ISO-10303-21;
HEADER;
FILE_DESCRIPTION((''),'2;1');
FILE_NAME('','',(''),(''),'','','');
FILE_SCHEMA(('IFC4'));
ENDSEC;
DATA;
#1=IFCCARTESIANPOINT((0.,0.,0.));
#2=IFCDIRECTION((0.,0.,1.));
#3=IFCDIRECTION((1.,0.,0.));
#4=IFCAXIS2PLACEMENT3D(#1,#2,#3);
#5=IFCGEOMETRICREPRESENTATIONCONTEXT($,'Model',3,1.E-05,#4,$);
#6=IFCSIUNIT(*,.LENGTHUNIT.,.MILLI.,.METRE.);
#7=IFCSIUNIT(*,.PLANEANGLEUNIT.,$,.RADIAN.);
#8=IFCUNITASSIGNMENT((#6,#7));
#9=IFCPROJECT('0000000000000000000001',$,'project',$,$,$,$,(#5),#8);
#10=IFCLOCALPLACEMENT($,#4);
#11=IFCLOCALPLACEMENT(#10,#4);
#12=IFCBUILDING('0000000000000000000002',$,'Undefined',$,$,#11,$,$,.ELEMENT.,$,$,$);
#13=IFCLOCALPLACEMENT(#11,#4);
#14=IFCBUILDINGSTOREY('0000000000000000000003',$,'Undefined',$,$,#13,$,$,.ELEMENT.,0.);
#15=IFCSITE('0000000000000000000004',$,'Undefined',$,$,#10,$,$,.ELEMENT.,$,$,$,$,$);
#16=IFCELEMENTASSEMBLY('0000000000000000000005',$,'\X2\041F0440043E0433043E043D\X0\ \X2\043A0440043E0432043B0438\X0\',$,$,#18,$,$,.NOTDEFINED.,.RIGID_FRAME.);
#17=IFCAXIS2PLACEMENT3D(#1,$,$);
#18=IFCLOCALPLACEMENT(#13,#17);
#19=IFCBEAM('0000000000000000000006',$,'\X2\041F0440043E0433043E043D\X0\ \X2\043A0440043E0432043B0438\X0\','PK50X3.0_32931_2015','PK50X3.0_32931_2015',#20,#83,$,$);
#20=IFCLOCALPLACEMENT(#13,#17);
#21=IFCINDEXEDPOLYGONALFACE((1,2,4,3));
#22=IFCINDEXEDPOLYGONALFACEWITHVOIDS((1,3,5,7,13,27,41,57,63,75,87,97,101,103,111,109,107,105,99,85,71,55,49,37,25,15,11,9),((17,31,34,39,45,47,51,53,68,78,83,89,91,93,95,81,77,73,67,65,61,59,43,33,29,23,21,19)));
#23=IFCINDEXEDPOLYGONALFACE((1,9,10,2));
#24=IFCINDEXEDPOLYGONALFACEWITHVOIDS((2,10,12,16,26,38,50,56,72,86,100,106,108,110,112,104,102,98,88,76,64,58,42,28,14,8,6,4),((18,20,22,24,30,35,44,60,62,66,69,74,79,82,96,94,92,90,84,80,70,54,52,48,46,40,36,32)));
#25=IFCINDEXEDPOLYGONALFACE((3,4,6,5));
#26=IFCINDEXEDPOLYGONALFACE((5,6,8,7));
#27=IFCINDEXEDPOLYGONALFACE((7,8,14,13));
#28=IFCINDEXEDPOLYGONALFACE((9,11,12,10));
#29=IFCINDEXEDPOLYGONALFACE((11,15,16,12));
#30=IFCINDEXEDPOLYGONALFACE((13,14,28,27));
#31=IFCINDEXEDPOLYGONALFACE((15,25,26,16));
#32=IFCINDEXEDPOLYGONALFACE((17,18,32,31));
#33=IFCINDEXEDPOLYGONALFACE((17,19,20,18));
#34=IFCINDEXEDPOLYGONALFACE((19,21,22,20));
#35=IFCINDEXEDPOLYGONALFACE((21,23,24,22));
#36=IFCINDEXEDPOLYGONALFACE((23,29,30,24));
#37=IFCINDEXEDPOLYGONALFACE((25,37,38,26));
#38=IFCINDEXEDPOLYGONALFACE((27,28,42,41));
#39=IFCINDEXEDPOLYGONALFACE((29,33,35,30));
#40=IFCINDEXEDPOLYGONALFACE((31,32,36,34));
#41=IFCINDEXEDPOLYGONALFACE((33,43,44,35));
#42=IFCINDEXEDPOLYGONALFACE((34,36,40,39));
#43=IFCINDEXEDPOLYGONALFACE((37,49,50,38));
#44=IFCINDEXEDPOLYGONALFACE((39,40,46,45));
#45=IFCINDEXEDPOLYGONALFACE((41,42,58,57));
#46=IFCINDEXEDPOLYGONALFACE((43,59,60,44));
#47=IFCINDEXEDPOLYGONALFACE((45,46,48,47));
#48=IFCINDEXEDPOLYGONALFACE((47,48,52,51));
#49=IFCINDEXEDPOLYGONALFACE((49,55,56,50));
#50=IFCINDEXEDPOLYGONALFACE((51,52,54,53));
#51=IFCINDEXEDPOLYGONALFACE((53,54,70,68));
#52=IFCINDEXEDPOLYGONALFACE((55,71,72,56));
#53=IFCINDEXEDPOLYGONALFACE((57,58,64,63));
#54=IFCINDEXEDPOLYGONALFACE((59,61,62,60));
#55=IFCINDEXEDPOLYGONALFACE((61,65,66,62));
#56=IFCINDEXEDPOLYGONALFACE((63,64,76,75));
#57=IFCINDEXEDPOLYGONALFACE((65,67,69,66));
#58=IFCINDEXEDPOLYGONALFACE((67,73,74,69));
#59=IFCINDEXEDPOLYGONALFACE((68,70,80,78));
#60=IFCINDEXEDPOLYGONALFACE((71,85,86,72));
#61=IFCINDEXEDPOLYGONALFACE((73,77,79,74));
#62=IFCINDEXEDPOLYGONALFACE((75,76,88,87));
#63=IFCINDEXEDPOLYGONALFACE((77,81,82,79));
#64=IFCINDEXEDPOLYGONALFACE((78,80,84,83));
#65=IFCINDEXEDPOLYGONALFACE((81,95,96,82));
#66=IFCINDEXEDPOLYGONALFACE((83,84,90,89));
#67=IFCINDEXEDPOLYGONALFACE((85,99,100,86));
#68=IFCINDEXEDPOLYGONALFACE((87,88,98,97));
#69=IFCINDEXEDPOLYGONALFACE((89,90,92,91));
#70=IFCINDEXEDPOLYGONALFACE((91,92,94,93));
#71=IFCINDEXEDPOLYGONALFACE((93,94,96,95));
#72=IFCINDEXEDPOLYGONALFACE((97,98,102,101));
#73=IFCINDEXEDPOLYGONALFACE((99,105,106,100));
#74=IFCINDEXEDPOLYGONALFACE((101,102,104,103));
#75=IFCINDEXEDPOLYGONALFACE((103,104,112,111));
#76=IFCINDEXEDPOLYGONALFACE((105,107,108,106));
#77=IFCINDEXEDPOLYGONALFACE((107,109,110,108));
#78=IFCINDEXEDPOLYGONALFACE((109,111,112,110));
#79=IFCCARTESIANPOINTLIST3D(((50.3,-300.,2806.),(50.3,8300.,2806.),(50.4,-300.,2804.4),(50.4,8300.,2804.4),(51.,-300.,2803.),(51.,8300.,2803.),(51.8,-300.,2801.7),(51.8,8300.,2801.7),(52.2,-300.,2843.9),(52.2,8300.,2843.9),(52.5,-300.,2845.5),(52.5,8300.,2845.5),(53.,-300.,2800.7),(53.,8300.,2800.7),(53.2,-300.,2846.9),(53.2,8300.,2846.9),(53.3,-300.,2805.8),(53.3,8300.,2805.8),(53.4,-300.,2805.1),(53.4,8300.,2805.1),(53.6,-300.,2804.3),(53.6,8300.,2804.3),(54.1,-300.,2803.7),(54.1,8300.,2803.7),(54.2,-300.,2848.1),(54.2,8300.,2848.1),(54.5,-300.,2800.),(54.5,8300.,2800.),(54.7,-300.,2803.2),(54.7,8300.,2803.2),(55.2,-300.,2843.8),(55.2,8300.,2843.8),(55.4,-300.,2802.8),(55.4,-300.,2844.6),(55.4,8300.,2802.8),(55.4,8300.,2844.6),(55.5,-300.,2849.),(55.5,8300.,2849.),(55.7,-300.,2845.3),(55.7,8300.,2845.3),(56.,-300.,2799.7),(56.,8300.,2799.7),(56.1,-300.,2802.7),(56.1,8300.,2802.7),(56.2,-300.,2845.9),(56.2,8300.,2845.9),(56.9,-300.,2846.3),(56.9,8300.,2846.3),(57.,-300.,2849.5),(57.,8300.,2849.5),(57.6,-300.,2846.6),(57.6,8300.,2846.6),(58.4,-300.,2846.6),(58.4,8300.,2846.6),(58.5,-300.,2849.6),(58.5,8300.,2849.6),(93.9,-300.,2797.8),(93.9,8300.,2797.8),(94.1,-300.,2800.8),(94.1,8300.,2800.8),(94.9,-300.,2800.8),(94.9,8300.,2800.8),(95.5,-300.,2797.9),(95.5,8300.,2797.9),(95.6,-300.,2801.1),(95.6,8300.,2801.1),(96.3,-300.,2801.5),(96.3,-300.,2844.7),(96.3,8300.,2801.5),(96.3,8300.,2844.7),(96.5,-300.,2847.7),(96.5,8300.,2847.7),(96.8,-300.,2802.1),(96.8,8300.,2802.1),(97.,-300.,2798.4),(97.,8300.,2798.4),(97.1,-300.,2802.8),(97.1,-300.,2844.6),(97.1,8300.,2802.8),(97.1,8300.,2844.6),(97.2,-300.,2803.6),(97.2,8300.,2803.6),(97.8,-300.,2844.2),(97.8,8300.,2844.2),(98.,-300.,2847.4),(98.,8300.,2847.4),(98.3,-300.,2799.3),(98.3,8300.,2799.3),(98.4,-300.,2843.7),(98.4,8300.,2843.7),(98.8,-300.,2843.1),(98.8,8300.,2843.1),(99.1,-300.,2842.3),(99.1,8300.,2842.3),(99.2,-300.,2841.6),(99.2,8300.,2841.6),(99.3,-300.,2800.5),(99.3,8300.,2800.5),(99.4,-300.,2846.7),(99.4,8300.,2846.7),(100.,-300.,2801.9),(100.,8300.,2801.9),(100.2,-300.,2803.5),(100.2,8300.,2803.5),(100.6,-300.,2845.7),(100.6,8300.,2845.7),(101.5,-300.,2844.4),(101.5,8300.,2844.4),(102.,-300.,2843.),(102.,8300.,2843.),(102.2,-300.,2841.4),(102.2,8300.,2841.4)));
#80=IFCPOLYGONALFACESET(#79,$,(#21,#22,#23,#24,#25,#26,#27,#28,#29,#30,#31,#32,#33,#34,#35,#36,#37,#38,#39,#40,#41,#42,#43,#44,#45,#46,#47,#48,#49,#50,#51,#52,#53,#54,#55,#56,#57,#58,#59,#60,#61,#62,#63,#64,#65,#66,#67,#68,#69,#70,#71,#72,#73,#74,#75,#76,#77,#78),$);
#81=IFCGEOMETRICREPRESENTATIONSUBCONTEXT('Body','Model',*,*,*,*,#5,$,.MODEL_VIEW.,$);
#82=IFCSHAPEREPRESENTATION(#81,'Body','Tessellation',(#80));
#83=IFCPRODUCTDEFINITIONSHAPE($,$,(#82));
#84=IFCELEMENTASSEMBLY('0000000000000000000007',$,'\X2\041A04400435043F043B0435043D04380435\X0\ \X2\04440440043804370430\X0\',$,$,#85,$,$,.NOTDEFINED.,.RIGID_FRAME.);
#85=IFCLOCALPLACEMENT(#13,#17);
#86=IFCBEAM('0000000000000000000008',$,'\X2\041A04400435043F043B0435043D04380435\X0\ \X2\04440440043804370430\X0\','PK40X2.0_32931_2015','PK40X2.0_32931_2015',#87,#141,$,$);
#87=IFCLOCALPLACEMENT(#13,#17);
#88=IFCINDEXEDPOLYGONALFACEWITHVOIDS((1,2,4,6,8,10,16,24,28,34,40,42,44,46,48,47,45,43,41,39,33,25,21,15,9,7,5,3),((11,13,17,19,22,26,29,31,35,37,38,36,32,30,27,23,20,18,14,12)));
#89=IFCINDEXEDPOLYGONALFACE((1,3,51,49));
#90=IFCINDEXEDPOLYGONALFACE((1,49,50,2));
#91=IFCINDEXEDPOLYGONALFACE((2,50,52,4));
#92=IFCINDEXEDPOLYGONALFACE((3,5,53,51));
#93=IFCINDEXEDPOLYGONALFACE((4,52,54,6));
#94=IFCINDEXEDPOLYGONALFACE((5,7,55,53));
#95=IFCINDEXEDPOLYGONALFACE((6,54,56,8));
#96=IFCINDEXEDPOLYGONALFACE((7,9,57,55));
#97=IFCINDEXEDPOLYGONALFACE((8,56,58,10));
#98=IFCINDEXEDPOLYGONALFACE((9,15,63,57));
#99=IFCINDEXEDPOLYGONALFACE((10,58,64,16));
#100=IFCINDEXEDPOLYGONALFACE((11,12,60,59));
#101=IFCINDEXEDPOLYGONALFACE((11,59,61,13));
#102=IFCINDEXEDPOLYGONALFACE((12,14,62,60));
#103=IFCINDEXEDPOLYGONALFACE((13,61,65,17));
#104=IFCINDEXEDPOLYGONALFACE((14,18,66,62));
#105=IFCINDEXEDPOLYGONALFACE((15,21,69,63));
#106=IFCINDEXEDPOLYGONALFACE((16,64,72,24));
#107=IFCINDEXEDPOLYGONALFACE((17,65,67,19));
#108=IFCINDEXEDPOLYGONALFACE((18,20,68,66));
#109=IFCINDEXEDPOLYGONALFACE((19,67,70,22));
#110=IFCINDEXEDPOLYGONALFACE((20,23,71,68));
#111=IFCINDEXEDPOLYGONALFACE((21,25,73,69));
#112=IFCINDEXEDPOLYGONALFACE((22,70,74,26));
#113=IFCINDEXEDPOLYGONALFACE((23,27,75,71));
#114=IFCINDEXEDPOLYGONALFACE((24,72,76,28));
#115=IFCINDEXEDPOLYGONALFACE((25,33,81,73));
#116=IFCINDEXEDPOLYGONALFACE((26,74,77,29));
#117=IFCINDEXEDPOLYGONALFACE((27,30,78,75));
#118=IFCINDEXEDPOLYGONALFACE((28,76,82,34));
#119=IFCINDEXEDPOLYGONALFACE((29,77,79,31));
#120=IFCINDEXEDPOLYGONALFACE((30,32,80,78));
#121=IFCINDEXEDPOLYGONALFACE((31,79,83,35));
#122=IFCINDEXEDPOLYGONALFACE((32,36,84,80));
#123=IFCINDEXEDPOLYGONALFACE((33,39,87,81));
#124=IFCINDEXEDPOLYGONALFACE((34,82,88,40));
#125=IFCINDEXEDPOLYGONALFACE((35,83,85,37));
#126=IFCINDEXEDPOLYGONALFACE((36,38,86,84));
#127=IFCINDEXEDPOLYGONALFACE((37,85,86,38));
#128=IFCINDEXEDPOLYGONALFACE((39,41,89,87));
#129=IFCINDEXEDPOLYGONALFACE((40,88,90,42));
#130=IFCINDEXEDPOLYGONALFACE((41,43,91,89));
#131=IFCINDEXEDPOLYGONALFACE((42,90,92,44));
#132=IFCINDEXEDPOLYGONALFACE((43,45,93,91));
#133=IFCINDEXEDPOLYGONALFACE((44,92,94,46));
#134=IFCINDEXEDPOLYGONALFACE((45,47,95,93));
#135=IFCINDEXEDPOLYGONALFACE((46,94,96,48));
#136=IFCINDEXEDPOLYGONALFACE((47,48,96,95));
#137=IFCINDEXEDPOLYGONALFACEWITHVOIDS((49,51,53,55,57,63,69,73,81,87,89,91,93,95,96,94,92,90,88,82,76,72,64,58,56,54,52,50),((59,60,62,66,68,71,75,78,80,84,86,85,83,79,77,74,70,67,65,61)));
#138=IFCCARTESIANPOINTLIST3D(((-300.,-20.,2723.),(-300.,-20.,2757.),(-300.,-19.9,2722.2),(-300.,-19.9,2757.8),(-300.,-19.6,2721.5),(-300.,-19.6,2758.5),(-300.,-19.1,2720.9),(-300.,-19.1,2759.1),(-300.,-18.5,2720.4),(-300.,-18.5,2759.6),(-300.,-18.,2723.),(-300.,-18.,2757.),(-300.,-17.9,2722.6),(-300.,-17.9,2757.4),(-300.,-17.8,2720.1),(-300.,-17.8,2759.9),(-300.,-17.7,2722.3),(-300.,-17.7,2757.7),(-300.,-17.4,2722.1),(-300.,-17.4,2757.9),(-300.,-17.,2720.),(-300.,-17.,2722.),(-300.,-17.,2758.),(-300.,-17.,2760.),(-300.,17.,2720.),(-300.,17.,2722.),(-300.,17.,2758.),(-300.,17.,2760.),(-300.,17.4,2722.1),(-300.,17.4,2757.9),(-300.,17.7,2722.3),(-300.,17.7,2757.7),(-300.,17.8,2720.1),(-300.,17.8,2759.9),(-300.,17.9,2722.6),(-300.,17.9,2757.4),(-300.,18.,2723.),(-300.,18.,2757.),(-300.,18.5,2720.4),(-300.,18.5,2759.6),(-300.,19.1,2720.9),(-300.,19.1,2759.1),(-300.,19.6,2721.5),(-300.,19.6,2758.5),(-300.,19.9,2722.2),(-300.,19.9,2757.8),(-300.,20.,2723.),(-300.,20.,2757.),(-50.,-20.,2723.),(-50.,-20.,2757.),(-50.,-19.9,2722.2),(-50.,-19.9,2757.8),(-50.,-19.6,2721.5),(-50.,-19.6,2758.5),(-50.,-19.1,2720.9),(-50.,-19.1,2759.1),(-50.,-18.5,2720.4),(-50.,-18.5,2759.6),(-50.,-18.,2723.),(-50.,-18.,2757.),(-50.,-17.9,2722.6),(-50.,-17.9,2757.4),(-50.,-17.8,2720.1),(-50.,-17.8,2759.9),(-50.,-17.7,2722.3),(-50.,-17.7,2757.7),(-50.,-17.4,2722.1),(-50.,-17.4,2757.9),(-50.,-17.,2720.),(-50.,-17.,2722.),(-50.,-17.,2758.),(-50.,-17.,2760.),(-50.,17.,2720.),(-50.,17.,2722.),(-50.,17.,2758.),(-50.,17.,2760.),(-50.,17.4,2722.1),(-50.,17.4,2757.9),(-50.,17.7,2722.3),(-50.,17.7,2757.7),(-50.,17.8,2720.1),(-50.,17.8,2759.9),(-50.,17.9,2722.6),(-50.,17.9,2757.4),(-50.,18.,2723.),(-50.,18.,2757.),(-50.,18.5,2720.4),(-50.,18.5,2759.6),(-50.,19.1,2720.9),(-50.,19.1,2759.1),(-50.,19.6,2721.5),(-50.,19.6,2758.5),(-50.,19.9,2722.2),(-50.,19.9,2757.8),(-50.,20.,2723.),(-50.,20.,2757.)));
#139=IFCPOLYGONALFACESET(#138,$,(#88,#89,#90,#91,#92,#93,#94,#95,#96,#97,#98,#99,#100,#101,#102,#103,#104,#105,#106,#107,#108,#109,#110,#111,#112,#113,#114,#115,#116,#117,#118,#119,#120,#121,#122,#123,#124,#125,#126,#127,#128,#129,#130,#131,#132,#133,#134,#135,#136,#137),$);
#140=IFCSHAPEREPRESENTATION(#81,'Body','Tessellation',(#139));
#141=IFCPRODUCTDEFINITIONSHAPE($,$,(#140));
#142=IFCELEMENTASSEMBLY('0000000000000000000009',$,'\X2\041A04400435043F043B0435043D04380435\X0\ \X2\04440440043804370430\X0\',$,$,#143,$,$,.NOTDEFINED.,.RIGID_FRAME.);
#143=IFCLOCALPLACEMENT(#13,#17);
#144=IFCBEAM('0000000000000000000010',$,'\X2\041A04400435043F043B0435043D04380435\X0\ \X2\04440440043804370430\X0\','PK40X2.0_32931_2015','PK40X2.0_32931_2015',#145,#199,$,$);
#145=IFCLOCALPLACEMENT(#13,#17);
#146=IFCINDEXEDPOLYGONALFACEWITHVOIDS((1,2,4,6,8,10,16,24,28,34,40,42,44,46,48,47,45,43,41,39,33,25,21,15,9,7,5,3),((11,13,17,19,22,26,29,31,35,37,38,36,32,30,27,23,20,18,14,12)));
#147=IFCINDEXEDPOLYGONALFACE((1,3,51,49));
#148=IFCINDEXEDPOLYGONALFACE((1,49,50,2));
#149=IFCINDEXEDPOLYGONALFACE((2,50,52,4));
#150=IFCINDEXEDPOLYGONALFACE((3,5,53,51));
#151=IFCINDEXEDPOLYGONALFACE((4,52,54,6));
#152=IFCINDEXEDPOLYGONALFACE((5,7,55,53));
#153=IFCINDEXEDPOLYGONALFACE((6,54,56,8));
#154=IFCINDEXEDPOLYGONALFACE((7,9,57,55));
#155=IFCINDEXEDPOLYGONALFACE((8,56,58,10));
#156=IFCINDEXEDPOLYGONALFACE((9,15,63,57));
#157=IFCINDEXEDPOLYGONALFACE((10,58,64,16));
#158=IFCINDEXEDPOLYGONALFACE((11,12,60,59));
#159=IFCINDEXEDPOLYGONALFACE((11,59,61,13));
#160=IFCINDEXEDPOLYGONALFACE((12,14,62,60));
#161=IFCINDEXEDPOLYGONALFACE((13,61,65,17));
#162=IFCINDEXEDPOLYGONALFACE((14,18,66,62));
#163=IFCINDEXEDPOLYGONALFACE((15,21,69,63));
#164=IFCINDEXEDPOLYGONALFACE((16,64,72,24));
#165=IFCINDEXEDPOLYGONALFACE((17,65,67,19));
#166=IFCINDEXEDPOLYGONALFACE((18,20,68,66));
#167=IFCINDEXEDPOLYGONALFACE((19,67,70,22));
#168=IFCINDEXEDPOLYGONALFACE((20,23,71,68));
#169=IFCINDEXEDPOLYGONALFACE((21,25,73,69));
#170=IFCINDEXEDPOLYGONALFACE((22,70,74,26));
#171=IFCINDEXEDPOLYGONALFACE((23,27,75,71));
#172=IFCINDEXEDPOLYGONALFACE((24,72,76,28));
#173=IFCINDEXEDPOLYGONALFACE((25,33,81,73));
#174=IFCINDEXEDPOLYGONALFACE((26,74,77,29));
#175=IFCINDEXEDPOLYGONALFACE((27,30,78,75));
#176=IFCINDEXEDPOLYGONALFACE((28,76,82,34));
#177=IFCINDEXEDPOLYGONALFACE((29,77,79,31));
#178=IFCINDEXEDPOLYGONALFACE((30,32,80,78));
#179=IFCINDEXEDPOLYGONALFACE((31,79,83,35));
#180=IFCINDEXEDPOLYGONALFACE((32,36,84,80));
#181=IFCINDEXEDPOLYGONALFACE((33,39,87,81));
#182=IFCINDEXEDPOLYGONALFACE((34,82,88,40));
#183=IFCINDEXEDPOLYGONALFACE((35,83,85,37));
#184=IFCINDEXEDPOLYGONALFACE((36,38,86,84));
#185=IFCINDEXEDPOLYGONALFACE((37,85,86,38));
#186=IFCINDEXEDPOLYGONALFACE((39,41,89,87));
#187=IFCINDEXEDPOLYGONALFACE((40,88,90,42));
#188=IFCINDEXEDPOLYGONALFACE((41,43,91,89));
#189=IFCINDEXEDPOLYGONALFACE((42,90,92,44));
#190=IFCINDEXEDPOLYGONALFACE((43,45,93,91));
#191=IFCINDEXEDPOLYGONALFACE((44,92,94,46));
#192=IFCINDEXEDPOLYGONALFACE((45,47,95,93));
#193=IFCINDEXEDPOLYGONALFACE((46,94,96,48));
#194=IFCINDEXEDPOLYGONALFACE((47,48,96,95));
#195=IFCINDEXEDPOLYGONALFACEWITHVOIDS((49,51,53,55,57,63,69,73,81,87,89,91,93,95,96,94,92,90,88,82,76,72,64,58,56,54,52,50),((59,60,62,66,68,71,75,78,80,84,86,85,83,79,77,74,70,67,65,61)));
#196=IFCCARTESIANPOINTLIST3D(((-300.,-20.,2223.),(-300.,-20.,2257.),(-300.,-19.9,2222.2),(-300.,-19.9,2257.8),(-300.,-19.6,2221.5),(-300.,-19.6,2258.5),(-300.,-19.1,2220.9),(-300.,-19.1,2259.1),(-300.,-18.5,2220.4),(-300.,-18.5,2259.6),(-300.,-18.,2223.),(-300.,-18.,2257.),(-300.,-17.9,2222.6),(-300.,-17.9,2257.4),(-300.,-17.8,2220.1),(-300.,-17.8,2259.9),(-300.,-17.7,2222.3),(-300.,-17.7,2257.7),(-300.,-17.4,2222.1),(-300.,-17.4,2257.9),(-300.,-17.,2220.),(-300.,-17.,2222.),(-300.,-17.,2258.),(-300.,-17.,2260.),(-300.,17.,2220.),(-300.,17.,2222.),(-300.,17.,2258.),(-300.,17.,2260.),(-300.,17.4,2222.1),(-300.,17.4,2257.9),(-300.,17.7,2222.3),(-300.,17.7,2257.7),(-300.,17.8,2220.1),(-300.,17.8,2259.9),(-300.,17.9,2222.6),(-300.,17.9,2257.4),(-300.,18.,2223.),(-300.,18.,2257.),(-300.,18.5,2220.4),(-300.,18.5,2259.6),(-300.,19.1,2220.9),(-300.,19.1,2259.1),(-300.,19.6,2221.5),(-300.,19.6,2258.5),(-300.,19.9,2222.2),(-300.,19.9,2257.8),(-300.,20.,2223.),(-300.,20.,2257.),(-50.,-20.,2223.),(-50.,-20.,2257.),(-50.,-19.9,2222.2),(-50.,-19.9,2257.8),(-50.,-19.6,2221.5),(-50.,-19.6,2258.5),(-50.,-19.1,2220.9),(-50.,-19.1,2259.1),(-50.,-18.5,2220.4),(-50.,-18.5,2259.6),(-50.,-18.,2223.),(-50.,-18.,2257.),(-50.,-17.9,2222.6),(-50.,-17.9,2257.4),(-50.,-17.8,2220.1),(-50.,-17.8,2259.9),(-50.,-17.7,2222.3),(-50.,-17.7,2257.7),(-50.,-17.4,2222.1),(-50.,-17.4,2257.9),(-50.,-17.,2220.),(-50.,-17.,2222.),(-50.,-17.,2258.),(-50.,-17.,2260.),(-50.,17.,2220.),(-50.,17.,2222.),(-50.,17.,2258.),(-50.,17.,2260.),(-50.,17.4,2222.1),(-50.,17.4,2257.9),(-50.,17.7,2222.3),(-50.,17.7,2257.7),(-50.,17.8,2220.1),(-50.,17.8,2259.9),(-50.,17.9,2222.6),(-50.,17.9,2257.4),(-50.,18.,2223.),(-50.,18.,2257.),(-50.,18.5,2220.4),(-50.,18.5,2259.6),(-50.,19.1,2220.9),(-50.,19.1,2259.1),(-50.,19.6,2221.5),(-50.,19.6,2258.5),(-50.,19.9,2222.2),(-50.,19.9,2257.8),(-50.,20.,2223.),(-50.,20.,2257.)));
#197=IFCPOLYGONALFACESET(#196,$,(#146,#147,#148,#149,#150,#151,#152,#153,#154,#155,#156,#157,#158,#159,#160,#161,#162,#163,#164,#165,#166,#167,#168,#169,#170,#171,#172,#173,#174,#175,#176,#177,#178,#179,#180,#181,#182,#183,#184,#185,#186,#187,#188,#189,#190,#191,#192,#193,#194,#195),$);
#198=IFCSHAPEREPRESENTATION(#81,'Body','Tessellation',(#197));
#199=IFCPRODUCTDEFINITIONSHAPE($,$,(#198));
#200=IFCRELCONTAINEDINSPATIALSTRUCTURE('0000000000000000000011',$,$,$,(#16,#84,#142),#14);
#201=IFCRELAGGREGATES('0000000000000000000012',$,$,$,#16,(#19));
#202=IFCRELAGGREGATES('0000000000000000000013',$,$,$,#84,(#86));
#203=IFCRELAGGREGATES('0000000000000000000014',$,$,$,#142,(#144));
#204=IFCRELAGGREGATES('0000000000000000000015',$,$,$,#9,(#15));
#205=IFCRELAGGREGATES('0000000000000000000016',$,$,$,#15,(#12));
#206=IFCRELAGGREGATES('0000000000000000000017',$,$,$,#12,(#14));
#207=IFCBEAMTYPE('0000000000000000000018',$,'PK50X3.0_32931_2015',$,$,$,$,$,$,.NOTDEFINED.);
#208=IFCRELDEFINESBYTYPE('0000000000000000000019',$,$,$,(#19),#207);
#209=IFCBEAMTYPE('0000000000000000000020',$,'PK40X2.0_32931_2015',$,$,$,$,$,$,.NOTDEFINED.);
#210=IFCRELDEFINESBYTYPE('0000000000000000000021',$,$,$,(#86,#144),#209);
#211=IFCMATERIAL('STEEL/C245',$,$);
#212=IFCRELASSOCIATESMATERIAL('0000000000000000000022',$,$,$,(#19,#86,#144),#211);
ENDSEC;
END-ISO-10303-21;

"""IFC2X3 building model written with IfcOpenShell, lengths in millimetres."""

from ifc_helpers import new_model, si_unit, frame, origin_with_axes, origin_2d_with_axis, place, context, subcontext, project, spatial, hollow_rectangle, extrude, material, type_object, element, aggregate, save


model = new_model("IFC2X3")

# Units and contexts
model_context = context("Model", 3, precision=1e-05, world=origin_with_axes())
body_context = subcontext(model_context, "Body", "Model", "MODEL_VIEW")
ifc_project = project(units=[si_unit("LENGTHUNIT", "METRE", prefix="MILLI"), si_unit("PLANEANGLEUNIT", "RADIAN")], contexts=[model_context])

# Site, building, storey
site_placement = place(None, origin_with_axes())
site = spatial("IfcSite", under=ifc_project, at=site_placement, Name="Undefined", CompositionType="ELEMENT")
building_placement = place(site_placement, origin_with_axes())
building = spatial("IfcBuilding", under=site, at=building_placement, Name="Undefined", CompositionType="ELEMENT")
storey_placement = place(building_placement, origin_with_axes())
storey = spatial("IfcBuildingStorey", under=building, at=storey_placement, Name="Undefined", CompositionType="ELEMENT", Elevation=0.0)

# Shared definitions
ifc_material_1 = material(Name="STEEL/C245")

# Shared definitions
beam_type_1 = type_object("IfcBeamType", Name="PK50X3.0_32931_2015", PredefinedType="NOTDEFINED")

# Element assemblies, beams
assembly_1_placement = place(storey_placement, origin_with_axes())
assembly_1 = element("IfcElementAssembly", 1, at=assembly_1_placement, inside=storey, Name="Прогон кровли", AssemblyPlace="NOTDEFINED", PredefinedType="RIGID_FRAME")
beam_1_placement = place(assembly_1_placement, frame((76.2, -300.0, 2823.7), z_axis=(0.050782, 0.0, 0.99871), x_axis=(0.0, 1.0, 0.0)))
beam_1 = element("IfcBeam", 2, at=beam_1_placement, type_object=beam_type_1, material=ifc_material_1, Name="Прогон кровли", Description="PK50X3.0_32931_2015", ObjectType="PK50X3.0_32931_2015", context=body_context, shape_type="SweptSolid", body=[
    extrude(hollow_rectangle(XDim=50.0, YDim=50.0, WallThickness=3.0, InnerFilletRadius=3.0, OuterFilletRadius=6.0, at=origin_2d_with_axis()), frame((8600.0, 0.0, 0.0), z_axis=(-1.0, 0.0, 0.0), x_axis=(0.0, -1.0, 0.0)), (0.0, 0.0, 1.0), 8600.0),
])
aggregate(assembly_1, [beam_1])
assembly_2_placement = place(storey_placement, origin_with_axes())
assembly_2 = element("IfcElementAssembly", 3, at=assembly_2_placement, inside=storey, Name="Крепление фриза", AssemblyPlace="NOTDEFINED", PredefinedType="RIGID_FRAME")
beam_type_2 = type_object("IfcBeamType", Name="PK40X2.0_32931_2015", PredefinedType="NOTDEFINED")
beam_2_placement = place(assembly_2_placement, frame((-300.0, 0.0, 2740.0), z_axis=(0.0, 0.0, -1.0), x_axis=(1.0, 0.0, 0.0)))
beam_2 = element("IfcBeam", 4, at=beam_2_placement, type_object=beam_type_2, material=ifc_material_1, Name="Крепление фриза", Description="PK40X2.0_32931_2015", ObjectType="PK40X2.0_32931_2015", context=body_context, shape_type="SweptSolid", body=[
    extrude(hollow_rectangle(XDim=40.0, YDim=40.0, WallThickness=2.0, InnerFilletRadius=1.0, OuterFilletRadius=3.0, at=origin_2d_with_axis()), frame((250.0, 0.0, 0.0), z_axis=(-1.0, 0.0, 0.0), x_axis=(0.0, -1.0, 0.0)), (0.0, 0.0, 1.0), 250.0),
])
aggregate(assembly_2, [beam_2])
assembly_3_placement = place(storey_placement, origin_with_axes())
assembly_3 = element("IfcElementAssembly", 5, at=assembly_3_placement, inside=storey, Name="Крепление фриза", AssemblyPlace="NOTDEFINED", PredefinedType="RIGID_FRAME")
beam_3_placement = place(assembly_3_placement, frame((-300.0, 0.0, 2240.0), z_axis=(0.0, 0.0, -1.0), x_axis=(1.0, 0.0, 0.0)))
beam_3 = element("IfcBeam", 6, at=beam_3_placement, type_object=beam_type_2, material=ifc_material_1, Name="Крепление фриза", Description="PK40X2.0_32931_2015", ObjectType="PK40X2.0_32931_2015", context=body_context, shape_type="SweptSolid", body=[
    extrude(hollow_rectangle(XDim=40.0, YDim=40.0, WallThickness=2.0, InnerFilletRadius=1.0, OuterFilletRadius=3.0, at=origin_2d_with_axis()), frame((250.0, 0.0, 0.0), z_axis=(-1.0, 0.0, 0.0), x_axis=(0.0, -1.0, 0.0)), (0.0, 0.0, 1.0), 250.0),
])
aggregate(assembly_3, [beam_3])

save(model, "model.ifc")
